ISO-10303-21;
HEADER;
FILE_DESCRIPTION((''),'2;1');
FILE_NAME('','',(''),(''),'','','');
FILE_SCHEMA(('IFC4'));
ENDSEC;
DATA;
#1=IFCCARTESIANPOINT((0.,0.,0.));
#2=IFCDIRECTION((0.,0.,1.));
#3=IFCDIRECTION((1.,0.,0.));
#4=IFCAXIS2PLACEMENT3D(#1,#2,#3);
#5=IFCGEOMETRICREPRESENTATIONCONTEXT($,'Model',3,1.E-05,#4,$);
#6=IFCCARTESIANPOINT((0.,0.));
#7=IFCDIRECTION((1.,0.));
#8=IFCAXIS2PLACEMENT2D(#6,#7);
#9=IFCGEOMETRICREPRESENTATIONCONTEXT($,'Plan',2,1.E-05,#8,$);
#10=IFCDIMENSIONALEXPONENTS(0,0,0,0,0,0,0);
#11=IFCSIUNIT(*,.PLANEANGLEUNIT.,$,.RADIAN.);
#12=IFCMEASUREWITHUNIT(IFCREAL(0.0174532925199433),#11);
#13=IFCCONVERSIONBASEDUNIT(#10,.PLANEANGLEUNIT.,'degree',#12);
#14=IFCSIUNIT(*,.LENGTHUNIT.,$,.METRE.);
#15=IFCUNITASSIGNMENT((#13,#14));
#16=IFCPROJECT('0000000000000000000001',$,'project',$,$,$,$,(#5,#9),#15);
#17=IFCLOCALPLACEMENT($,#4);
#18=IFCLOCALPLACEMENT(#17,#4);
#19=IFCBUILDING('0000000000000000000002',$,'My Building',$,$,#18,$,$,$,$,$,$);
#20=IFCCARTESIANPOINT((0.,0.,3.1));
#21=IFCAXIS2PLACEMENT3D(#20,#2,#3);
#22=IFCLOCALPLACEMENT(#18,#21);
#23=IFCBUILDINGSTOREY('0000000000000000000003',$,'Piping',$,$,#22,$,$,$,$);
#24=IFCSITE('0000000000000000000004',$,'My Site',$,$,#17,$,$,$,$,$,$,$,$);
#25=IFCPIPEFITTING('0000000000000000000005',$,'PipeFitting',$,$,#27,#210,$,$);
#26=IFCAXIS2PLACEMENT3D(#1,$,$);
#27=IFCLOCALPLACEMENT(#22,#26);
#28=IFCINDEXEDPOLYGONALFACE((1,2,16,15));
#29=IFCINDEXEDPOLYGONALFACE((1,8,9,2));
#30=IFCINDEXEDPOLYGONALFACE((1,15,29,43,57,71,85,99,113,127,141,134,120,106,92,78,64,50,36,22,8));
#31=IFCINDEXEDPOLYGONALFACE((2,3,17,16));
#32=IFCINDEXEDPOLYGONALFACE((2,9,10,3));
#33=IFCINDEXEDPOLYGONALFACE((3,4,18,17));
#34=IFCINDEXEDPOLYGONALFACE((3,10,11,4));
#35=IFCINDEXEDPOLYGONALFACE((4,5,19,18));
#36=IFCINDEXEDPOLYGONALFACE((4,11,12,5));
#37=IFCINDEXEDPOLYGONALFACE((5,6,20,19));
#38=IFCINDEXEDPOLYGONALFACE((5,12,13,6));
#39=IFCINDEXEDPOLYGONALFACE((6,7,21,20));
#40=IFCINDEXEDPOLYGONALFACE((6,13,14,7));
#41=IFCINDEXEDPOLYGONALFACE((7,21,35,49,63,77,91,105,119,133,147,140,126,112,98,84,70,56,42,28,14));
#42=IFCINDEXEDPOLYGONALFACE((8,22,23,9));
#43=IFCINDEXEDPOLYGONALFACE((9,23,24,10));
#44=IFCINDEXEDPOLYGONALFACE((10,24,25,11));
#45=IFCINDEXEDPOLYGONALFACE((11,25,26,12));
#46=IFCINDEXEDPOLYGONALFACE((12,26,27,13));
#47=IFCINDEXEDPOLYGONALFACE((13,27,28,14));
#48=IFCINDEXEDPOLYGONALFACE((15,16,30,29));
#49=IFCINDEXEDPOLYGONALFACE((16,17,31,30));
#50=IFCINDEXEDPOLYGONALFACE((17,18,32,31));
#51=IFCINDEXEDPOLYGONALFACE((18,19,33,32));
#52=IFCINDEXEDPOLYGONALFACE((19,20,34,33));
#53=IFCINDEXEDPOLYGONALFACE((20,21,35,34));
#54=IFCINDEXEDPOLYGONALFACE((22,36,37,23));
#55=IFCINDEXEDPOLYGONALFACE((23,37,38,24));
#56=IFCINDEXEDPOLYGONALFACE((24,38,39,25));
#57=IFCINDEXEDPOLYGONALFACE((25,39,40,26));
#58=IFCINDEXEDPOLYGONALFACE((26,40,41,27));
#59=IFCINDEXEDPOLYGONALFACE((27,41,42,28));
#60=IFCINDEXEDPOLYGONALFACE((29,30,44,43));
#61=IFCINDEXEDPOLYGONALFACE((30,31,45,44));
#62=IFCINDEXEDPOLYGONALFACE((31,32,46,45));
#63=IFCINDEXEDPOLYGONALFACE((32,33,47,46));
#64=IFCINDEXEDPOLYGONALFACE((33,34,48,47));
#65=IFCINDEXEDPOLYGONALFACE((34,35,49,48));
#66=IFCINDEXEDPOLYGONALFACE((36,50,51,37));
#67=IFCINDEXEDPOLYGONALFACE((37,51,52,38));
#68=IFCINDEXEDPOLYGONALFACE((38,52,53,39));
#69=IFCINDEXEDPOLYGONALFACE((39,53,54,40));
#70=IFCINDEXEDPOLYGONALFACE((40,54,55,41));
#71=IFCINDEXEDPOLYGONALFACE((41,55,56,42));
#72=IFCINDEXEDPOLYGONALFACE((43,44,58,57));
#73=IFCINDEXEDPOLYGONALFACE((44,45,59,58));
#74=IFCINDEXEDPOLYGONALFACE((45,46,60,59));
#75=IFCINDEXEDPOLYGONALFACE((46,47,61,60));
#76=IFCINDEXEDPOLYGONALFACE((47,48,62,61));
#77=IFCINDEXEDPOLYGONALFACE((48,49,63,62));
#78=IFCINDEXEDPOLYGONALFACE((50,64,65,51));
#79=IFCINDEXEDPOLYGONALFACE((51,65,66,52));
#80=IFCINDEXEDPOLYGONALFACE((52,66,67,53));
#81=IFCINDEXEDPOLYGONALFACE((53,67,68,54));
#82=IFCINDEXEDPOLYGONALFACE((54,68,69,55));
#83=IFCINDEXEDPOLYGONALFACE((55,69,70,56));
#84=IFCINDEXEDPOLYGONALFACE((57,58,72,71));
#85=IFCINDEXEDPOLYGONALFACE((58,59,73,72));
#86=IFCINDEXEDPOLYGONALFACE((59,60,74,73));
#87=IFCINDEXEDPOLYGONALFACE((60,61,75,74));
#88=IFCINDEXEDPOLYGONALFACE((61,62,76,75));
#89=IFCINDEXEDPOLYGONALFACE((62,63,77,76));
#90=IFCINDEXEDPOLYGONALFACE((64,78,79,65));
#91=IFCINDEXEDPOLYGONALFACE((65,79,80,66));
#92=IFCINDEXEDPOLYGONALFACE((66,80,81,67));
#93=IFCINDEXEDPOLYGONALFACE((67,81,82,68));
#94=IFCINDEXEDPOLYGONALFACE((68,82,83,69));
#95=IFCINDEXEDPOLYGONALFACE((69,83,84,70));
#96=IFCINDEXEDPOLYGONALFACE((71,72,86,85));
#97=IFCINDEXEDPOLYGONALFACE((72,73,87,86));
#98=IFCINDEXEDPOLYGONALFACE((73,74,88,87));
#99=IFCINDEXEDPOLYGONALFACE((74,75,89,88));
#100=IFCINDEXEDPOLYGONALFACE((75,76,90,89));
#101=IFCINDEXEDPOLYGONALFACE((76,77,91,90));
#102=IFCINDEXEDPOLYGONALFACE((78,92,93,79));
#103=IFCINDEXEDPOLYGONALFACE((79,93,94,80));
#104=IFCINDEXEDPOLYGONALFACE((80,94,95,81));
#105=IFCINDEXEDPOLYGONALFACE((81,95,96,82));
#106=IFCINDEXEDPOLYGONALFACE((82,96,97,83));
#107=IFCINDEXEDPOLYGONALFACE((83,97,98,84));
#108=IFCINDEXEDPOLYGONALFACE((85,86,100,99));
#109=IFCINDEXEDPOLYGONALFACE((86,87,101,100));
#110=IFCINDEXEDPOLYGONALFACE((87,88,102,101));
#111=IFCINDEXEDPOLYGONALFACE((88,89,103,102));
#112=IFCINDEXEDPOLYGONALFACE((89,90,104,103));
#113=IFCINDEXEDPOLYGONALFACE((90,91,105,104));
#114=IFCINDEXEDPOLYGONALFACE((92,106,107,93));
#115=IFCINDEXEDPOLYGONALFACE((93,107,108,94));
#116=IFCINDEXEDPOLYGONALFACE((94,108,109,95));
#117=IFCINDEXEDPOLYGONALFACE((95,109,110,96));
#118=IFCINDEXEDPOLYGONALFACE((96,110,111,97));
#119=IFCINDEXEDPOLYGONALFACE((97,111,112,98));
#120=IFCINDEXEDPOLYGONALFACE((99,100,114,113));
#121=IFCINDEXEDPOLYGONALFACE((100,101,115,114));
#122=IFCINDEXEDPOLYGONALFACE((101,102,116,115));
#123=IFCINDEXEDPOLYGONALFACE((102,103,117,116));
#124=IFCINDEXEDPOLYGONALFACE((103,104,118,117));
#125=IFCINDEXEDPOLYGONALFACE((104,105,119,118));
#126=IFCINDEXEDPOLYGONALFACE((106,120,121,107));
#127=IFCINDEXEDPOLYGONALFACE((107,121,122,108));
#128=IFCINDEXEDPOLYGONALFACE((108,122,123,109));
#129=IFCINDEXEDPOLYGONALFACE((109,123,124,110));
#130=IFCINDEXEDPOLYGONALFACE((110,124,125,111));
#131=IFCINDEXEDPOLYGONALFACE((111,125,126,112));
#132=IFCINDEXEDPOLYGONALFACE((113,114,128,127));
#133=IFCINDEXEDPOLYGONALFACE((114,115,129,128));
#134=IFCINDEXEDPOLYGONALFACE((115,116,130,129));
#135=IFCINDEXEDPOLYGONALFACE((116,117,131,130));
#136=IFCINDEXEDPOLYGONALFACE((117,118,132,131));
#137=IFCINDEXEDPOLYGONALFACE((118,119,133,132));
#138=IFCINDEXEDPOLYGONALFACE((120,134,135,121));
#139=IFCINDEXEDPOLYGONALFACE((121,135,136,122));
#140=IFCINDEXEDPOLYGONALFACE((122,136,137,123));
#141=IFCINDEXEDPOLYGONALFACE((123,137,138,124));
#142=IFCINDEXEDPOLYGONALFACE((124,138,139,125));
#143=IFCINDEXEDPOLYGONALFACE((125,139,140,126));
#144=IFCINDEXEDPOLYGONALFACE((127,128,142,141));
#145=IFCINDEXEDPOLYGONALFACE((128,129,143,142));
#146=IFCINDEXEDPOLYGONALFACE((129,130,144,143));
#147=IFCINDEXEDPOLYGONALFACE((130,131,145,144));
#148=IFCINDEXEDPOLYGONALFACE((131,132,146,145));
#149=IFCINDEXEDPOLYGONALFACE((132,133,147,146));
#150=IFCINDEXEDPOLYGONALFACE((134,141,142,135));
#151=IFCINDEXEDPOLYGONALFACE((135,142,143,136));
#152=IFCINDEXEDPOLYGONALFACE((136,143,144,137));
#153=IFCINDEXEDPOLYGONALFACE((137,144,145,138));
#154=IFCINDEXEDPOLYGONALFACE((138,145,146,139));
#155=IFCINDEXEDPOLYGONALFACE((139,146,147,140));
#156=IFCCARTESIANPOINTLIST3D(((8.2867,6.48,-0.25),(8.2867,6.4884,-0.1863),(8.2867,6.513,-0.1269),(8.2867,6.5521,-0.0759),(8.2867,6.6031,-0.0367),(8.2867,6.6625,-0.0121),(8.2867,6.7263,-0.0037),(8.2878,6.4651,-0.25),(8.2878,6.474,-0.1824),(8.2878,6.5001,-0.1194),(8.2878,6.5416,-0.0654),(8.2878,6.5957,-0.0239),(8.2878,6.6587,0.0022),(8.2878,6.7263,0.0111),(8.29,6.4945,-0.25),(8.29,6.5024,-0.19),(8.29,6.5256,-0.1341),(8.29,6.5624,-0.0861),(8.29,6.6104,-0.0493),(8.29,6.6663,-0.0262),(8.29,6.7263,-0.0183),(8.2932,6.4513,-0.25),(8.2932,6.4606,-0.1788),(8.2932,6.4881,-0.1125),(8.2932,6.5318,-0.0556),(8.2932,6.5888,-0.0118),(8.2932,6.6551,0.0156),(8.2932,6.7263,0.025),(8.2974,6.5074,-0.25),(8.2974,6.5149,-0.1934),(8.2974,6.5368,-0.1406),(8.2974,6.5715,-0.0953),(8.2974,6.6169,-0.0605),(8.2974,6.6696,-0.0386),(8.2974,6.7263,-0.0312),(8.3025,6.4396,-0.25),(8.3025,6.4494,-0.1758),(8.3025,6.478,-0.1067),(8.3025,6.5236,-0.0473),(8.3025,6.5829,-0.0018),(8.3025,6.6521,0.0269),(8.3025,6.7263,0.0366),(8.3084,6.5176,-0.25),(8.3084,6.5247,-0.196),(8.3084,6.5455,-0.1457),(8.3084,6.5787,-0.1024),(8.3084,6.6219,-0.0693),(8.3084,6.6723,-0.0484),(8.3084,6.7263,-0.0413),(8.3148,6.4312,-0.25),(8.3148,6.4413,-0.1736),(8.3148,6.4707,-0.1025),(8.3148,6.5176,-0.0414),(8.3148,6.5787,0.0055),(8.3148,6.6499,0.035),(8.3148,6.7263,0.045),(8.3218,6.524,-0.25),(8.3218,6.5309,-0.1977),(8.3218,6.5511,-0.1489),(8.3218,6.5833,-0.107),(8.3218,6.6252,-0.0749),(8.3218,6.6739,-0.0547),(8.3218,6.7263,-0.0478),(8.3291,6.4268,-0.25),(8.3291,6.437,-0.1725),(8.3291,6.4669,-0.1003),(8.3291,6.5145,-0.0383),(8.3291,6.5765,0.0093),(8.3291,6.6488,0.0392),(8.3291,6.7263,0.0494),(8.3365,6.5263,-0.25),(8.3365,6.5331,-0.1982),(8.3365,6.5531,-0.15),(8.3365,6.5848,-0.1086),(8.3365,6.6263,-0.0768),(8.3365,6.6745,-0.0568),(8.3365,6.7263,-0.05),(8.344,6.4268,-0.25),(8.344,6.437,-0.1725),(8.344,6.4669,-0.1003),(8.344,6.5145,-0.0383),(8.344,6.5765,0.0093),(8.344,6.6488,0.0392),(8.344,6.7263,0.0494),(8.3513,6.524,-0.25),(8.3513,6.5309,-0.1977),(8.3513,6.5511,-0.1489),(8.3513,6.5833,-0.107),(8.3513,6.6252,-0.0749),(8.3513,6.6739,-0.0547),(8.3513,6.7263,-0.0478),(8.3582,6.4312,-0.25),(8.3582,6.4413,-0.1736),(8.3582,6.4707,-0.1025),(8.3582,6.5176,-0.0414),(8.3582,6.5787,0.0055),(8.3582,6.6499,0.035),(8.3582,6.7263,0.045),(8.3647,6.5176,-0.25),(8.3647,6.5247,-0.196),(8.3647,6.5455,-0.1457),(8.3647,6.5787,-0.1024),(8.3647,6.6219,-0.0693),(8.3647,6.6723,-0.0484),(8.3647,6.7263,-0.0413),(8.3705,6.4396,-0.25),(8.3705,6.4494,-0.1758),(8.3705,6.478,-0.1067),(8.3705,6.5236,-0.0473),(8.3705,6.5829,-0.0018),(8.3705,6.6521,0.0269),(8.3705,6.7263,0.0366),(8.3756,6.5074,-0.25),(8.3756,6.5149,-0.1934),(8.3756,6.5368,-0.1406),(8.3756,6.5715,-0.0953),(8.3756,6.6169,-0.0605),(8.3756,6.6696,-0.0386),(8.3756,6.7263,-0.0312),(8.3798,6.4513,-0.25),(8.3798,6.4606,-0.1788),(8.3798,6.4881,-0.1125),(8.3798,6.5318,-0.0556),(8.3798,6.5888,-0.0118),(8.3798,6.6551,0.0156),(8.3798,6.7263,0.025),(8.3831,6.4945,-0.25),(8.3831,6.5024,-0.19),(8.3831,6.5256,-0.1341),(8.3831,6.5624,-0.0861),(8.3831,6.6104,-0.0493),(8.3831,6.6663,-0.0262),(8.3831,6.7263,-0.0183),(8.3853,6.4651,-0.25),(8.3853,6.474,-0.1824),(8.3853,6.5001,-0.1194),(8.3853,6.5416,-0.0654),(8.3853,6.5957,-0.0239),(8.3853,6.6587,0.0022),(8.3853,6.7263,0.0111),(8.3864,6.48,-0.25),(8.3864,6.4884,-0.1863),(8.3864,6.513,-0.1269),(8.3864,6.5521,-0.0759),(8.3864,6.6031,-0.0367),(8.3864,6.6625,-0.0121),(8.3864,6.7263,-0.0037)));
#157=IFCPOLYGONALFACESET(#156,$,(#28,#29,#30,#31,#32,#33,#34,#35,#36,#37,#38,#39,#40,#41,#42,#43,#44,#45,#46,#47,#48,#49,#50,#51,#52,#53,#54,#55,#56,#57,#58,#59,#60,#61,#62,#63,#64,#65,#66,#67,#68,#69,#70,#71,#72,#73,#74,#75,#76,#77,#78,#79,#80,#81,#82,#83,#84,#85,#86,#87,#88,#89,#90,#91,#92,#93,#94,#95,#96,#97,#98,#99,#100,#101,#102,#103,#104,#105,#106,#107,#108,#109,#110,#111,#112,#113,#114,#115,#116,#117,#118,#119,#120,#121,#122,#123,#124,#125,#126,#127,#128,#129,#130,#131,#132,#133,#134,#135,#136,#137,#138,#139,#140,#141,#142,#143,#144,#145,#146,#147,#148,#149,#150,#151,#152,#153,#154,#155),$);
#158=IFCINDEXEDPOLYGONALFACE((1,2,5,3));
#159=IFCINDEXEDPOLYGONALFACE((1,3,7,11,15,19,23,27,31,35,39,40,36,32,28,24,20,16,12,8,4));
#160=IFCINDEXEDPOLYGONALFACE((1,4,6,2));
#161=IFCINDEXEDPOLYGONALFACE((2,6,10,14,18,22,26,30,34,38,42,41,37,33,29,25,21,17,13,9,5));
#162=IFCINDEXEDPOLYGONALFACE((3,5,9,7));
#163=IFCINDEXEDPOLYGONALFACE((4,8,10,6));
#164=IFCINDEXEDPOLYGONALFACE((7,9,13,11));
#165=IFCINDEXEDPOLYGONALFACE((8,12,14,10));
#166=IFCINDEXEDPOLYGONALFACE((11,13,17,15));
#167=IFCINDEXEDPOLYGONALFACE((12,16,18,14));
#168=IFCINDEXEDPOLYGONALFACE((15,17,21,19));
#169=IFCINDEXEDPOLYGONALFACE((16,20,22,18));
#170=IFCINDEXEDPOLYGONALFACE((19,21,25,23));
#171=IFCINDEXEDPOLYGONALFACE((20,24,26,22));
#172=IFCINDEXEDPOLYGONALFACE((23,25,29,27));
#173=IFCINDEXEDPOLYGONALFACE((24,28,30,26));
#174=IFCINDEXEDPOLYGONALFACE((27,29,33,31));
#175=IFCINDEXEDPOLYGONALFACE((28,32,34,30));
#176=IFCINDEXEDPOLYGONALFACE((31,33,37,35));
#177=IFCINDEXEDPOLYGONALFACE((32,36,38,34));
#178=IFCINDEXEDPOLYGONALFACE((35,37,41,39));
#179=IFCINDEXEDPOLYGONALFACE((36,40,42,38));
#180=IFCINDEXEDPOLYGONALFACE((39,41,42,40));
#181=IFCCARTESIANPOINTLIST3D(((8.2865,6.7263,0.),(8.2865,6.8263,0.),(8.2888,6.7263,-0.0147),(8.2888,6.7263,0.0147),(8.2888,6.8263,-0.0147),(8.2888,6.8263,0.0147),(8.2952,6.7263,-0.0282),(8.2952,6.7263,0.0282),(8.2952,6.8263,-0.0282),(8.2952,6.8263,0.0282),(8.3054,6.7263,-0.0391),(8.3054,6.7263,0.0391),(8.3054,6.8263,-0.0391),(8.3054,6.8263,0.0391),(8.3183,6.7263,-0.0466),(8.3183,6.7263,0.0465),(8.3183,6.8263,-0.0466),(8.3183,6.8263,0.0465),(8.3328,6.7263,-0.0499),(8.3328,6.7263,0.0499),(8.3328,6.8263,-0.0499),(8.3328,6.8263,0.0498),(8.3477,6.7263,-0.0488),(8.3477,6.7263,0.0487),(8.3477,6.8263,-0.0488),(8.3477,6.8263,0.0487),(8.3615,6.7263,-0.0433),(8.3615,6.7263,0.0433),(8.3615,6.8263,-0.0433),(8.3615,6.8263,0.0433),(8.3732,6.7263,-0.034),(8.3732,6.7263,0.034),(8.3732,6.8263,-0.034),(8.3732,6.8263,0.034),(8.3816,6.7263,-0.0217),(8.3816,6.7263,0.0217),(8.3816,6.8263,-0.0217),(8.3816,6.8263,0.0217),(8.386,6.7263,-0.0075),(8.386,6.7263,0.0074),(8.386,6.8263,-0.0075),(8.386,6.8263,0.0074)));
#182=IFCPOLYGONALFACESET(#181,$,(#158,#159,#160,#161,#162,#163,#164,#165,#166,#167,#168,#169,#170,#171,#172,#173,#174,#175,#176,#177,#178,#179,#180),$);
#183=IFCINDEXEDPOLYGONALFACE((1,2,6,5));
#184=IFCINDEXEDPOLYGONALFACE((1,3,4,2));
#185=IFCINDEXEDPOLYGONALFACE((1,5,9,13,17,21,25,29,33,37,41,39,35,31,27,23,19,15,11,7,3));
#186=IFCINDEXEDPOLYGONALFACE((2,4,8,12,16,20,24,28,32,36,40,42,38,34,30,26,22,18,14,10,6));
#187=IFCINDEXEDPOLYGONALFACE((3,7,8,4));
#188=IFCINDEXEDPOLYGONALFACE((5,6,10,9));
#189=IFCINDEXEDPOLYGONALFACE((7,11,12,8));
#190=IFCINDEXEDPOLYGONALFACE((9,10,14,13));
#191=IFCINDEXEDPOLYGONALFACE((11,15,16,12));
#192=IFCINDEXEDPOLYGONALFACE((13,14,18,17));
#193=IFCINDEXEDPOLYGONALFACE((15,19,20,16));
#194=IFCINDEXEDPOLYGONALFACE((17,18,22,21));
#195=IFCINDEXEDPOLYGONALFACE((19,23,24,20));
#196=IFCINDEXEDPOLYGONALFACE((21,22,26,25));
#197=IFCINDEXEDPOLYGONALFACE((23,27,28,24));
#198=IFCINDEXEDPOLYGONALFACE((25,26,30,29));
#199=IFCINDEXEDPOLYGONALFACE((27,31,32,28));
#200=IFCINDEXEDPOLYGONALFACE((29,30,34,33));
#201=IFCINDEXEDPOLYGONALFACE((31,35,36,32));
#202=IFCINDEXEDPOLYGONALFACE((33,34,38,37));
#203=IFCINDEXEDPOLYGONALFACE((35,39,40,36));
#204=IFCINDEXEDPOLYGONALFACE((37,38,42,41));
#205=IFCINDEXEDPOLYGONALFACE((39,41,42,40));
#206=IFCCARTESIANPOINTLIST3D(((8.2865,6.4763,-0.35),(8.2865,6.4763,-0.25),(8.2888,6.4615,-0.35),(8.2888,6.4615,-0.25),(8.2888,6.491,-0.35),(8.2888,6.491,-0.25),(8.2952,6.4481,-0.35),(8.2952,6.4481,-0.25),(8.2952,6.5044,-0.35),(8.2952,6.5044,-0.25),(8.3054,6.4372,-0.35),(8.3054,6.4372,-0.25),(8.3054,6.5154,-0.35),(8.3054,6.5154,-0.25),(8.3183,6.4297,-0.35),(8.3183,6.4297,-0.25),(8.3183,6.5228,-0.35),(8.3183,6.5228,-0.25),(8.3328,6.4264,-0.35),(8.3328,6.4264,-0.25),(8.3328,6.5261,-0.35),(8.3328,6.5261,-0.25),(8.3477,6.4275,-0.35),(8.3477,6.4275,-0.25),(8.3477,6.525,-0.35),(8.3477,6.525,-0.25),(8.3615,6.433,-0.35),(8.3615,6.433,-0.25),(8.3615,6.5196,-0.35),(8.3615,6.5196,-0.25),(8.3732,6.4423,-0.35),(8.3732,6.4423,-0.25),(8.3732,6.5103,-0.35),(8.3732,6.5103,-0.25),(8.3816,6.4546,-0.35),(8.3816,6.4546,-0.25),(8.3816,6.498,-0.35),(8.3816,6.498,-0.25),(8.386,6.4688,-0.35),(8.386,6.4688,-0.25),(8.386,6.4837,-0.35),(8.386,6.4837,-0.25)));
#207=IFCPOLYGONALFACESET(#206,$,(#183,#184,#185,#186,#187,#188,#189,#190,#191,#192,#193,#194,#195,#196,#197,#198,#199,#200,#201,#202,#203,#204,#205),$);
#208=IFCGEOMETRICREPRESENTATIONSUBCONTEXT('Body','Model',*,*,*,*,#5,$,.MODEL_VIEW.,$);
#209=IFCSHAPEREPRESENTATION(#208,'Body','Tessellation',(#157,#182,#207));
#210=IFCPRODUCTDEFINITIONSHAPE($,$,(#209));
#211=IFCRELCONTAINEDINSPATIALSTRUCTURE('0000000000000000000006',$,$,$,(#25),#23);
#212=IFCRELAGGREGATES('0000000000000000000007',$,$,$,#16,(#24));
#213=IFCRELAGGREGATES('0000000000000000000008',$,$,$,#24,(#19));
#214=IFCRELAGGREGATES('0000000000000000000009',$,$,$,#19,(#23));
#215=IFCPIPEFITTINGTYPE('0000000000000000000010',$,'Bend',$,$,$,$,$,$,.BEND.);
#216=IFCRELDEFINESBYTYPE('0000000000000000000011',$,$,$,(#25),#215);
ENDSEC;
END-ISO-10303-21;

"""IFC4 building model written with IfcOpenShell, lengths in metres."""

from ifc_helpers import new_model, entity, si_unit, converted_unit, frame, origin_with_axes, origin_2d_with_axis, place, context, subcontext, project, spatial, circle, extrude, source, transform, mapped, type_object, type_shapes, element, save


model = new_model("IFC4")

# Units and contexts
model_context = context("Model", 3, precision=1e-05, world=origin_with_axes())
plan_context = context("Plan", 2, precision=1e-05, world=origin_2d_with_axis())
body_context = subcontext(model_context, "Body", "Model", "MODEL_VIEW")
ifc_project = project(units=[converted_unit("PLANEANGLEUNIT", "degree", entity("IfcReal", 0.0174532925199433), si_unit("PLANEANGLEUNIT", "RADIAN"), dimensions=[0, 0, 0, 0, 0, 0, 0]), si_unit("LENGTHUNIT", "METRE")], contexts=[model_context, plan_context])

# Site, building, storey
site_placement = place(None, origin_with_axes())
site = spatial("IfcSite", under=ifc_project, at=site_placement, Name="My Site")
building_placement = place(site_placement, origin_with_axes())
building = spatial("IfcBuilding", under=site, at=building_placement, Name="My Building")
storey_placement = place(building_placement, frame((0.0, 0.0, 3.1), z_axis=(0.0, 0.0, 1.0), x_axis=(1.0, 0.0, 0.0)))
storey = spatial("IfcBuildingStorey", under=building, at=storey_placement, Name="Piping")

# Pipe fitting
pipe_fitting_type_1 = type_object("IfcPipeFittingType", Name="Bend", PredefinedType="BEND")
shared_shape_1 = source(origin_with_axes(), body_context, "Body", "SolidModel", [
    entity("IfcSweptDiskSolid", entity("IfcIndexedPolyCurve", entity("IfcCartesianPointList3D", [[0.0, 0.0, -0.1], [0.0, -0.0732, -0.2768], [0.0, -0.25, -0.35]]), [entity("IfcArcIndex", [1, 2, 3])]), 0.05),
    extrude(circle(Radius=0.05), origin_with_axes(), (0.0, 0.0, -1.0), 0.1),
    extrude(circle(Radius=0.05), frame((0.0, -0.25, -0.35), z_axis=(0.0, -1.0, 0.000022), x_axis=(1.0, 0.0, 0.0)), (0.0, 0.0, 1.0), 0.1),
])
type_shapes(pipe_fitting_type_1, [shared_shape_1])
for number, where, z_axis, x_axis, name in (
    (1, (8.3365, 6.8263, 0.0), (0.0, 1.0, -0.000022), (-1.0, 0.0, 0.0), "PipeFitting"),
):
    element("IfcPipeFitting", number, at=place(storey_placement, frame(where, z_axis=z_axis, x_axis=x_axis)), inside=storey, type_object=pipe_fitting_type_1, Name=name, context=body_context, shape_type="MappedRepresentation", body=[
        mapped(shared_shape_1, transform((0.0, 0.0, 0.0), x_axis=(1.0, 0.0, 0.0), y_axis=(0.0, 1.0, 0.0), z_axis=(0.0, 0.0, 1.0), scale=1.0)),
    ])

save(model, "model.ifc")
